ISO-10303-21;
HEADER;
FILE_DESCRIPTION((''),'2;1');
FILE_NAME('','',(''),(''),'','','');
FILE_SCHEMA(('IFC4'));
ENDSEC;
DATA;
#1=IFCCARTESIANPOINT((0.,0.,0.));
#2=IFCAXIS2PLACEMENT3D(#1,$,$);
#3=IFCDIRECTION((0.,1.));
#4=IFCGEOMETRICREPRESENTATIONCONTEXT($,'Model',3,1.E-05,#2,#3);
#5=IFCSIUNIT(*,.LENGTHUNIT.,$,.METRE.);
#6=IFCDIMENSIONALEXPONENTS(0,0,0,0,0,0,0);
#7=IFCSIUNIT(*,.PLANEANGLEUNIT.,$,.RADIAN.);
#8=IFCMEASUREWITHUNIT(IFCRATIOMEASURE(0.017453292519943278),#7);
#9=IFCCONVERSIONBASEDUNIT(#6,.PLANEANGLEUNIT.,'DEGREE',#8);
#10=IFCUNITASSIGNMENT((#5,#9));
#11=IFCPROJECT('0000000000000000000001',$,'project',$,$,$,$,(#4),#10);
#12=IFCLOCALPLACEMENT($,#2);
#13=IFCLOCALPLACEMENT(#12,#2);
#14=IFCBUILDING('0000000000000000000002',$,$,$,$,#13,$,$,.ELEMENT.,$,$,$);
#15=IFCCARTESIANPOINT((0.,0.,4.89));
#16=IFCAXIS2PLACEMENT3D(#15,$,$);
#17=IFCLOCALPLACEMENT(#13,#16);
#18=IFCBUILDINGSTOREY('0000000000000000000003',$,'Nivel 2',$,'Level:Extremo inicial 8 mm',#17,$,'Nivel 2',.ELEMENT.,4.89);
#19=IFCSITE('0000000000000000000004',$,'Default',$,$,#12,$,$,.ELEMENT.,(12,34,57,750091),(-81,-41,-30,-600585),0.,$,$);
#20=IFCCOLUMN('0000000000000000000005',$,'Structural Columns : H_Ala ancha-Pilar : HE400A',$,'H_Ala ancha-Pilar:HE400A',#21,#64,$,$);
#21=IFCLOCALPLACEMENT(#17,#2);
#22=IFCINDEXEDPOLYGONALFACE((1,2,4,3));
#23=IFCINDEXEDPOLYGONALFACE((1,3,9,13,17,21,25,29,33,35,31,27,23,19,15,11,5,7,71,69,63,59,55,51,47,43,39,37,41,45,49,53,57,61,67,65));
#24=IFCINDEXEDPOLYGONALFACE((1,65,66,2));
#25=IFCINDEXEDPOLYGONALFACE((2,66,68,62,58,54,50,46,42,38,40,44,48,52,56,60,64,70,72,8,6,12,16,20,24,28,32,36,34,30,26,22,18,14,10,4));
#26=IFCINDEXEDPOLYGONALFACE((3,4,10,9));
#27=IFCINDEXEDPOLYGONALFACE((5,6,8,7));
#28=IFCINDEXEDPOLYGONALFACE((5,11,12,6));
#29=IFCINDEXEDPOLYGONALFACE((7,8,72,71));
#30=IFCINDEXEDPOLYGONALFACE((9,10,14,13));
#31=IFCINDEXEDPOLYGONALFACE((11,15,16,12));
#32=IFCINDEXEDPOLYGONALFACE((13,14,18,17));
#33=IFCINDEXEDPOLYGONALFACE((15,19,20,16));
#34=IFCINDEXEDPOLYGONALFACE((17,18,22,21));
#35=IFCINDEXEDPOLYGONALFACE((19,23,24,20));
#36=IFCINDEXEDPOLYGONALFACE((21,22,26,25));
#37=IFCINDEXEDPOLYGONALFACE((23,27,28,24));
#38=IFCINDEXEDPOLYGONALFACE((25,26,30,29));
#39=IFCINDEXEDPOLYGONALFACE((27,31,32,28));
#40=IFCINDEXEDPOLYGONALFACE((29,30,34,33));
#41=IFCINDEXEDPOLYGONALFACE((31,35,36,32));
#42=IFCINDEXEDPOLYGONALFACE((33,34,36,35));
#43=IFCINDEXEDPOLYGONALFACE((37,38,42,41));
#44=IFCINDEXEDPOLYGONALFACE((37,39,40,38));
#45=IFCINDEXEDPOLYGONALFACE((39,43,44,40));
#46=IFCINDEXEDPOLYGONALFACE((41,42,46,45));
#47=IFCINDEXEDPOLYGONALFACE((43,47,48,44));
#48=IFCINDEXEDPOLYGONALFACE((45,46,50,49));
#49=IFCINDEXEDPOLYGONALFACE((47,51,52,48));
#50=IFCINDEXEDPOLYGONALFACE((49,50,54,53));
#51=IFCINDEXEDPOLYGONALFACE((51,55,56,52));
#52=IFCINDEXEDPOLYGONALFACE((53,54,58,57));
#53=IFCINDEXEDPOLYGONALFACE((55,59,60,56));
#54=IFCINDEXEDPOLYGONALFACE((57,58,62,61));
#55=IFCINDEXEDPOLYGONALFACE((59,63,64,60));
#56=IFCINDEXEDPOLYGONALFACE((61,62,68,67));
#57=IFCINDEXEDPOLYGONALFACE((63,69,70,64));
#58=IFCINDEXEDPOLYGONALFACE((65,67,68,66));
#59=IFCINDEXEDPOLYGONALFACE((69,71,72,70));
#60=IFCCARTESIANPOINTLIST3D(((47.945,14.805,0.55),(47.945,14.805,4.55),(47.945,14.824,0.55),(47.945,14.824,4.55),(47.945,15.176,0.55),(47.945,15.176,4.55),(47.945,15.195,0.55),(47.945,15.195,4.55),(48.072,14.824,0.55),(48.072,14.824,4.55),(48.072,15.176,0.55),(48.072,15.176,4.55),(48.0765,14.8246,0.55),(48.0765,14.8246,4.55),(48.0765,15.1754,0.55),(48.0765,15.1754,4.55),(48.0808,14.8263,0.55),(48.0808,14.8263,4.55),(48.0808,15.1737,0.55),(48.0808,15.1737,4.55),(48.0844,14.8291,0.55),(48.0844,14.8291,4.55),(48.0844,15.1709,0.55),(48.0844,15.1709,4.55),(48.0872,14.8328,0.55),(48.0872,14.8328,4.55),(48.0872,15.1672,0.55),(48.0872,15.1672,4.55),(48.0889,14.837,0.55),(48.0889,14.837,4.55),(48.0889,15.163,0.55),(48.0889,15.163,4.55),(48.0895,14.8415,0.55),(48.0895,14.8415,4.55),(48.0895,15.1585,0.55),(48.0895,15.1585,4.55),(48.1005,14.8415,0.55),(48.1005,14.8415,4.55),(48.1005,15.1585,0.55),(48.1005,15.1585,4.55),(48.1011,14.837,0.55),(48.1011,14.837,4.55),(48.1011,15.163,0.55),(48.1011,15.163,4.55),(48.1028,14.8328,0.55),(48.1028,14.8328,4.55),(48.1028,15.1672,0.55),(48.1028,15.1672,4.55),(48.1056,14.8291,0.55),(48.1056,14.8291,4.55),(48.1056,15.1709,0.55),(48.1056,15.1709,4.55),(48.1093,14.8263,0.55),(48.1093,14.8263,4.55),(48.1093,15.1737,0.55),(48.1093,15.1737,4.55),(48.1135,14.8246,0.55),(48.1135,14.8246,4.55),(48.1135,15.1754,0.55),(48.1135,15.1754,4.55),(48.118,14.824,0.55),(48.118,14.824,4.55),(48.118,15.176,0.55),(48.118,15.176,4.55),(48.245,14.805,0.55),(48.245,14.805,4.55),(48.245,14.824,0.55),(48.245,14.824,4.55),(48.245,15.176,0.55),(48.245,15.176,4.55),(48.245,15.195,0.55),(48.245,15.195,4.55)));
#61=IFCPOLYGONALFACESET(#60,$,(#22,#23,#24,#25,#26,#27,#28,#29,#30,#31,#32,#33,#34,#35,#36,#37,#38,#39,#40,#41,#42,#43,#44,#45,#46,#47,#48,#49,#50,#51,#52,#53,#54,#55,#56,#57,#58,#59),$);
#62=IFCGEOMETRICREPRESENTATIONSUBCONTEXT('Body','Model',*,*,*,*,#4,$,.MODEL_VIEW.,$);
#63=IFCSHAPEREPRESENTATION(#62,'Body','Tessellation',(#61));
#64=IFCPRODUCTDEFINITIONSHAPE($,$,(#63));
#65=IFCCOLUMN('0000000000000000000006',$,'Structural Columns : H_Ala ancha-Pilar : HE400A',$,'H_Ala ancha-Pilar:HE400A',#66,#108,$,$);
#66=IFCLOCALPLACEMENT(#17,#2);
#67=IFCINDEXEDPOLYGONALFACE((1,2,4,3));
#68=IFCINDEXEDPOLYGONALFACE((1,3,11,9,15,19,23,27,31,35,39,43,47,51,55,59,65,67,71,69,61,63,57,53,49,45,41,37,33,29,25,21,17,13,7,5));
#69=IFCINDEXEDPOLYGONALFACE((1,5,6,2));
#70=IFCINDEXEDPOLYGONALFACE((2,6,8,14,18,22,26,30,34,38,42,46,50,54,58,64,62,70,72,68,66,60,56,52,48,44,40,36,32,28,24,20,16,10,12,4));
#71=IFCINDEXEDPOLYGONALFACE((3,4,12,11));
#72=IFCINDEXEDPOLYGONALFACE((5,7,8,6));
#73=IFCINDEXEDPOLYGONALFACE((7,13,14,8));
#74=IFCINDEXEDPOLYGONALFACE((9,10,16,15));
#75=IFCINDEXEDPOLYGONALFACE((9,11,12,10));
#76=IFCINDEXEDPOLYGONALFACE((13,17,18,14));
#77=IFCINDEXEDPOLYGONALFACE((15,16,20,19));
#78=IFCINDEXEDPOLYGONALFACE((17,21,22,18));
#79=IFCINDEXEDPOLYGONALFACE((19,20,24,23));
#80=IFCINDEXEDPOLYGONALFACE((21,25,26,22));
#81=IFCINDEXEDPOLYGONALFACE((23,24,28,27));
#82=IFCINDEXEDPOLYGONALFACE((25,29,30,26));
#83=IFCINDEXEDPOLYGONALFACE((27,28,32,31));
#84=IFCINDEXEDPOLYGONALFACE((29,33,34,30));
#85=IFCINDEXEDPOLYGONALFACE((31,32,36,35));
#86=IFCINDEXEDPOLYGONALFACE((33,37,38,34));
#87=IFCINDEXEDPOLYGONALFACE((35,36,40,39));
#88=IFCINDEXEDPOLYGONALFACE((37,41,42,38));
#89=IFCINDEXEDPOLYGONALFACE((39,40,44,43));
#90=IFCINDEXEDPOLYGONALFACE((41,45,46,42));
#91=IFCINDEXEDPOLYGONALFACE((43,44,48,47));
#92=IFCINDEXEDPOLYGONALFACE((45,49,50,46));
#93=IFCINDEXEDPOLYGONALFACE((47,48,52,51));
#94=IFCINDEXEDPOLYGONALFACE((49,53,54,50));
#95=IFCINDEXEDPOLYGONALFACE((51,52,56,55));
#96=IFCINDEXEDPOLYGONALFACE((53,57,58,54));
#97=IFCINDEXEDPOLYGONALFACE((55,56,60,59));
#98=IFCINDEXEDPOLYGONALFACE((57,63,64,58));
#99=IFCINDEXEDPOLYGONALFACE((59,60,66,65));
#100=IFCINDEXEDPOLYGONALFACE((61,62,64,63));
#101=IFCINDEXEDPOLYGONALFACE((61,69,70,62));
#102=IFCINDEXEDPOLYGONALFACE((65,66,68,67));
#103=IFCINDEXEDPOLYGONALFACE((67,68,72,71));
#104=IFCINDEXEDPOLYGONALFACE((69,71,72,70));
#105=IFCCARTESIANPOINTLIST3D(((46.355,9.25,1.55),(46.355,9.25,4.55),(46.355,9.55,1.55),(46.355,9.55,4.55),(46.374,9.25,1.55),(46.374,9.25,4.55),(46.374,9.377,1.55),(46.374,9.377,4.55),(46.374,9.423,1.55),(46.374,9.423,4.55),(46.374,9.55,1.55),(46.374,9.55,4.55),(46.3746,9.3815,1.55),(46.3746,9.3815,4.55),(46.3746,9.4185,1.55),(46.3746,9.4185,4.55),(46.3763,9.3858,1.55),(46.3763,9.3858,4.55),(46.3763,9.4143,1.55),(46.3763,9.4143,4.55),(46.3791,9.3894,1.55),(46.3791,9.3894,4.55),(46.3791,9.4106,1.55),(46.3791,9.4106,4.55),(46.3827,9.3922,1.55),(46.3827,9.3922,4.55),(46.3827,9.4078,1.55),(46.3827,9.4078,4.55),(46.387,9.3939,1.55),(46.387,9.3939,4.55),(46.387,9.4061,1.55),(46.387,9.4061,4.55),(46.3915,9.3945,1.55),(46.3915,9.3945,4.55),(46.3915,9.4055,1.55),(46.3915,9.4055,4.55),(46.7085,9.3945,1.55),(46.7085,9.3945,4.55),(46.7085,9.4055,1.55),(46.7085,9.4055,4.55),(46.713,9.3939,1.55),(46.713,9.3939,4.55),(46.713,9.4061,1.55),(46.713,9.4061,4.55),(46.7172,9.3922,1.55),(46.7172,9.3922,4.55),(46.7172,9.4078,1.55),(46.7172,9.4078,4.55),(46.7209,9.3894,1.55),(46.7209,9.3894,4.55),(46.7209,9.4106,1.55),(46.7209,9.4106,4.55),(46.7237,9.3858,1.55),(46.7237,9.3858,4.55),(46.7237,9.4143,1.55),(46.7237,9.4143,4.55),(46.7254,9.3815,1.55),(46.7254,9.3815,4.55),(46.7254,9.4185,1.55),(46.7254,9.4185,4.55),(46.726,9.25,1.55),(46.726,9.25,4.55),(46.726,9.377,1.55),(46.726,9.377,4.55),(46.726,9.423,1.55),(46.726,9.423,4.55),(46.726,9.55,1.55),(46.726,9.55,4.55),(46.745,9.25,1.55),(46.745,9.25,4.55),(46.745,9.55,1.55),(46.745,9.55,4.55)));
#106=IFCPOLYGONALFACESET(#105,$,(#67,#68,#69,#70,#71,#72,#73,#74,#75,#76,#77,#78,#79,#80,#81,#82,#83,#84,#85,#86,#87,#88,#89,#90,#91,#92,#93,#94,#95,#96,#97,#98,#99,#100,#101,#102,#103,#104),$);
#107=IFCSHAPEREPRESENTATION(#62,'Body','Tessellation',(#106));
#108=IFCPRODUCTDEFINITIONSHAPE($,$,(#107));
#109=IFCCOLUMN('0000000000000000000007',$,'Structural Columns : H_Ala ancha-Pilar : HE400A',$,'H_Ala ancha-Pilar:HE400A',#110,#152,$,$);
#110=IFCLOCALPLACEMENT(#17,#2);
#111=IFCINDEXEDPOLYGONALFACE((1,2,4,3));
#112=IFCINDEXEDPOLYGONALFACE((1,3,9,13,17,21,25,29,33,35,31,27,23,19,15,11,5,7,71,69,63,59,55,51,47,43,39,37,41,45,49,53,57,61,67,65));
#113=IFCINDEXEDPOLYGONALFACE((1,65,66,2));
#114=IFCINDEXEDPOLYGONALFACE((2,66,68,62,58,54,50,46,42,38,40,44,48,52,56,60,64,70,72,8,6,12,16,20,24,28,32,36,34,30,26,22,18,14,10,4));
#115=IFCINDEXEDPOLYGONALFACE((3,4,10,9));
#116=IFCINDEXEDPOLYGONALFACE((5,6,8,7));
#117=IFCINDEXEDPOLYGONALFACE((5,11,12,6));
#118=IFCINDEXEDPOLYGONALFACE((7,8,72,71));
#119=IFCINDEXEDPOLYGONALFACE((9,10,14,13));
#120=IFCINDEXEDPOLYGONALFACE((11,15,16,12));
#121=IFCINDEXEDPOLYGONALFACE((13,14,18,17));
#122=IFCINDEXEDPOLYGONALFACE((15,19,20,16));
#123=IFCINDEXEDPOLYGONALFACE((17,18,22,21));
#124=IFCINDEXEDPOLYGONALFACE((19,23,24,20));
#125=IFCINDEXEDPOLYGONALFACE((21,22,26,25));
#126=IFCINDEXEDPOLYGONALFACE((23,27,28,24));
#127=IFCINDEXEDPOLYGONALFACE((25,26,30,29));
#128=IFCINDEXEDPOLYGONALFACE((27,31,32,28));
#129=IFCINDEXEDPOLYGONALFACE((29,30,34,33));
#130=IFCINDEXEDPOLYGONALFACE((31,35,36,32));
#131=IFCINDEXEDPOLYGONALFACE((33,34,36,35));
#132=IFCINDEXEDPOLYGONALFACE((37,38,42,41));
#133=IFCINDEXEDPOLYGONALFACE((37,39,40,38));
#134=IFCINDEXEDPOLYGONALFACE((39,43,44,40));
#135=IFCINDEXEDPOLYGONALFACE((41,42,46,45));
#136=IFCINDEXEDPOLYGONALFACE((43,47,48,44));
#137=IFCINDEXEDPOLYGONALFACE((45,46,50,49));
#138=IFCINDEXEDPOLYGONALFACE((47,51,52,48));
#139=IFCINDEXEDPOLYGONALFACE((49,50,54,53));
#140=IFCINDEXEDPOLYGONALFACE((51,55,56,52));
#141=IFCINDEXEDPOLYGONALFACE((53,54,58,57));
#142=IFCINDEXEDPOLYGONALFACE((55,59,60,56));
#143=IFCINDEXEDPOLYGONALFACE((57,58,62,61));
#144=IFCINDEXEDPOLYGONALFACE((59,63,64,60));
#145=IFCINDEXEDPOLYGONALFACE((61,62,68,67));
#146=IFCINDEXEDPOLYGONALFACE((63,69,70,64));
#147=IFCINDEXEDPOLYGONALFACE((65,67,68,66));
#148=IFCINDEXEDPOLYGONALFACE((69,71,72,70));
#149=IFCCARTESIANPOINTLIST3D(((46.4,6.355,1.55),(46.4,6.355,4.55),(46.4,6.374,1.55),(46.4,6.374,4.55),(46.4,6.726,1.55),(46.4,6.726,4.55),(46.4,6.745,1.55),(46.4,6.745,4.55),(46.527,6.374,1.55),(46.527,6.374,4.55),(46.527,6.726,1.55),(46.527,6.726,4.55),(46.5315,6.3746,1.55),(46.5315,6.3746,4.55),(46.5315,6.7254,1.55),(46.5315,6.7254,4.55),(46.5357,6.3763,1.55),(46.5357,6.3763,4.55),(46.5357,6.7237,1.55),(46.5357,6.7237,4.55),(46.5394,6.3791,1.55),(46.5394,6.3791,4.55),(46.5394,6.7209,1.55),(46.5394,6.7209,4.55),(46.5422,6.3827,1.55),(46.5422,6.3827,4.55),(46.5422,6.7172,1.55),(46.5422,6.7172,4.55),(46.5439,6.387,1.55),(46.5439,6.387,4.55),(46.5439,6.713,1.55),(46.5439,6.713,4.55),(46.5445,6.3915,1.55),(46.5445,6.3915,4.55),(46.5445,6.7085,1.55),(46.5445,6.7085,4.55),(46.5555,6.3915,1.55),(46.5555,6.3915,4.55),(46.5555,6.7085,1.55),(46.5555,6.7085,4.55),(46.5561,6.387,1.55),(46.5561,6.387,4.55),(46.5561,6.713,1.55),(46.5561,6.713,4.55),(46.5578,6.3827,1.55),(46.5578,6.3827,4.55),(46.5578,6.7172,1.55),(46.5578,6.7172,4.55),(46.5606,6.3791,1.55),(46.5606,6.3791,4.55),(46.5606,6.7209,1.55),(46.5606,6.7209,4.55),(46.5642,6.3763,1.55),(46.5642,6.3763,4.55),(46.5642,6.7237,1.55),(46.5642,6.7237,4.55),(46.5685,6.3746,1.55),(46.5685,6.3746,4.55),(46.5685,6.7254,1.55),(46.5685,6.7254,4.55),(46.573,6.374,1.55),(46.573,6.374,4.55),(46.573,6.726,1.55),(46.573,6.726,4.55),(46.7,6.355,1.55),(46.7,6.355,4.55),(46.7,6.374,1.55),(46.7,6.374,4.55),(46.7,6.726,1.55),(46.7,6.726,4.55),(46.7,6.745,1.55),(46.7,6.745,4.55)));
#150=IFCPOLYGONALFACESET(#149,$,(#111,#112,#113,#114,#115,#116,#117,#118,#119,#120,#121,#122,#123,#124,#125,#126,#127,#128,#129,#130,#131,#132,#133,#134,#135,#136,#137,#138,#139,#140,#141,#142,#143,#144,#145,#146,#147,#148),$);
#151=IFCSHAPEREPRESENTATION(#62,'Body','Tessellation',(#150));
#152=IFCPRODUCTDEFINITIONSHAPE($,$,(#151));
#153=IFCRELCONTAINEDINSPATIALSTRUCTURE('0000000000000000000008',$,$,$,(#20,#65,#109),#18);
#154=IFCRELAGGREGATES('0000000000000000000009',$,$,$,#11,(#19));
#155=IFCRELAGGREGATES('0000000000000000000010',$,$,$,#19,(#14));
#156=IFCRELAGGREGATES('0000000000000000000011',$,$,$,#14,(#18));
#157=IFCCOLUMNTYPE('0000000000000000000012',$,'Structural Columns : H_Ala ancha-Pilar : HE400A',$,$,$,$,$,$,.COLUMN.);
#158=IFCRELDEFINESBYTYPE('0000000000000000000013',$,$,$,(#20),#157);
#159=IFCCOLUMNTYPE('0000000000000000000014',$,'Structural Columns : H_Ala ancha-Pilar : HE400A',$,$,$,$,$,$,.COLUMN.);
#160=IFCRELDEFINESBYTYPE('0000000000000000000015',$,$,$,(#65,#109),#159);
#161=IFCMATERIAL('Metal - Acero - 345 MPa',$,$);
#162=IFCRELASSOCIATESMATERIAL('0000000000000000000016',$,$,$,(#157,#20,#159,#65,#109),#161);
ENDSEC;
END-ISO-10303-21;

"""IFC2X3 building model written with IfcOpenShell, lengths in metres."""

from ifc_helpers import new_model, entity, si_unit, converted_unit, direction, frame, frame_2d, origin, place, context, subcontext, project, spatial, polyline, circle_curve, parameter, trimmed, segment, composite_curve, outline, extrude, source, transform, mapped, material, type_object, type_shapes, element, save


model = new_model("IFC2X3")

# Units and contexts
model_context = context("Model", 3, precision=1e-05, world=origin(), true_north=direction((0.0, 1.0)))
body_context = subcontext(model_context, "Body", "Model", "MODEL_VIEW")
ifc_project = project(units=[si_unit("LENGTHUNIT", "METRE"), converted_unit("PLANEANGLEUNIT", "DEGREE", entity("IfcRatioMeasure", 0.017453292519943278), si_unit("PLANEANGLEUNIT", "RADIAN"), dimensions=[0, 0, 0, 0, 0, 0, 0])], contexts=[model_context])

# Site, building, storey
site_placement = place(None, origin())
site = spatial("IfcSite", under=ifc_project, at=site_placement, Name="Default", CompositionType="ELEMENT", RefLatitude=(12, 34, 57, 750091), RefLongitude=(-81, -41, -30, -600585), RefElevation=0.0)
building_placement = place(site_placement, origin())
building = spatial("IfcBuilding", under=site, at=building_placement, CompositionType="ELEMENT")
storey_placement = place(building_placement, frame((0.0, 0.0, 4.89)))
storey = spatial("IfcBuildingStorey", under=building, at=storey_placement, Name="Nivel 2", ObjectType="Level:Extremo inicial 8 mm", LongName="Nivel 2", CompositionType="ELEMENT", Elevation=4.89)

# Columns
ifc_material_1 = material(Name="Metal - Acero - 345 MPa")
column_type_1 = type_object("IfcColumnType", Name="Structural Columns : H_Ala ancha-Pilar : HE400A", PredefinedType="COLUMN", material=ifc_material_1)
shared_shape_1 = source(origin(), body_context, "Body", "SweptSolid", [
    extrude(outline(composite_curve([segment(polyline([(0.176, -0.15), (0.195, -0.15)]), True, "CONTINUOUS"), segment(polyline([(0.195, -0.15), (0.195, 0.15)]), True, "CONTINUOUS"), segment(polyline([(0.195, 0.15), (0.176, 0.15)]), True, "CONTINUOUS"), segment(polyline([(0.176, 0.15), (0.176, 0.023)]), True, "CONTINUOUS"), segment(trimmed(circle_curve(frame_2d((0.1585, 0.023), x_axis=(1.0, 0.0)), 0.0175), [parameter(270.0)], [parameter(0.0)], True, "PARAMETER"), False, "CONTINUOUS"), segment(polyline([(0.1585, 0.0055), (-0.1585, 0.0055)]), True, "CONTINUOUS"), segment(trimmed(circle_curve(frame_2d((-0.1585, 0.023), x_axis=(0.0, -1.0)), 0.0175), [parameter(270.0)], [parameter(0.0)], True, "PARAMETER"), False, "CONTINUOUS"), segment(polyline([(-0.176, 0.023), (-0.176, 0.15)]), True, "CONTINUOUS"), segment(polyline([(-0.176, 0.15), (-0.195, 0.15)]), True, "CONTINUOUS"), segment(polyline([(-0.195, 0.15), (-0.195, -0.15)]), True, "CONTINUOUS"), segment(polyline([(-0.195, -0.15), (-0.176, -0.15)]), True, "CONTINUOUS"), segment(polyline([(-0.176, -0.15), (-0.176, -0.023)]), True, "CONTINUOUS"), segment(trimmed(circle_curve(frame_2d((-0.1585, -0.023), x_axis=(-1.0, 0.0)), 0.0175), [parameter(270.0)], [parameter(0.0)], True, "PARAMETER"), False, "CONTINUOUS"), segment(polyline([(-0.1585, -0.0055), (0.1585, -0.0055)]), True, "CONTINUOUS"), segment(trimmed(circle_curve(frame_2d((0.1585, -0.023), x_axis=(0.0, 1.0)), 0.0175), [parameter(270.0)], [parameter(0.0)], True, "PARAMETER"), False, "CONTINUOUS"), segment(polyline([(0.176, -0.023), (0.176, -0.15)]), True, "CONTINUOUS")], self_intersect=False)), frame((0.0, 0.0, 5.44), z_axis=(0.0, 0.0, 1.0), x_axis=(0.0, -1.0, 0.0)), (0.0, 0.0, 1.0), 4.0),
])
type_shapes(column_type_1, [shared_shape_1])
column_1_placement = place(storey_placement, frame((48.095, 15.0, -4.89), z_axis=(0.0, 0.0, 1.0), x_axis=(-1.0, 0.0, 0.0)))
element("IfcColumn", 1, at=column_1_placement, inside=storey, type_object=column_type_1, material=ifc_material_1, Name="Structural Columns : H_Ala ancha-Pilar : HE400A", ObjectType="H_Ala ancha-Pilar:HE400A", context=body_context, shape_type="MappedRepresentation", body=[
    mapped(shared_shape_1, transform((0.0, 0.0, 0.0), scale=1.0)),
])
column_type_2 = type_object("IfcColumnType", Name="Structural Columns : H_Ala ancha-Pilar : HE400A", PredefinedType="COLUMN", material=ifc_material_1)
shared_shape_2 = source(origin(), body_context, "Body", "SweptSolid", [
    extrude(outline(composite_curve([segment(polyline([(0.176, -0.15), (0.195, -0.15)]), True, "CONTINUOUS"), segment(polyline([(0.195, -0.15), (0.195, 0.15)]), True, "CONTINUOUS"), segment(polyline([(0.195, 0.15), (0.176, 0.15)]), True, "CONTINUOUS"), segment(polyline([(0.176, 0.15), (0.176, 0.023)]), True, "CONTINUOUS"), segment(trimmed(circle_curve(frame_2d((0.1585, 0.023), x_axis=(1.0, 0.0)), 0.0175), [parameter(270.0)], [parameter(0.0)], True, "PARAMETER"), False, "CONTINUOUS"), segment(polyline([(0.1585, 0.0055), (-0.1585, 0.0055)]), True, "CONTINUOUS"), segment(trimmed(circle_curve(frame_2d((-0.1585, 0.023), x_axis=(0.0, -1.0)), 0.0175), [parameter(270.0)], [parameter(0.0)], True, "PARAMETER"), False, "CONTINUOUS"), segment(polyline([(-0.176, 0.023), (-0.176, 0.15)]), True, "CONTINUOUS"), segment(polyline([(-0.176, 0.15), (-0.195, 0.15)]), True, "CONTINUOUS"), segment(polyline([(-0.195, 0.15), (-0.195, -0.15)]), True, "CONTINUOUS"), segment(polyline([(-0.195, -0.15), (-0.176, -0.15)]), True, "CONTINUOUS"), segment(polyline([(-0.176, -0.15), (-0.176, -0.023)]), True, "CONTINUOUS"), segment(trimmed(circle_curve(frame_2d((-0.1585, -0.023), x_axis=(-1.0, 0.0)), 0.0175), [parameter(270.0)], [parameter(0.0)], True, "PARAMETER"), False, "CONTINUOUS"), segment(polyline([(-0.1585, -0.0055), (0.1585, -0.0055)]), True, "CONTINUOUS"), segment(trimmed(circle_curve(frame_2d((0.1585, -0.023), x_axis=(0.0, 1.0)), 0.0175), [parameter(270.0)], [parameter(0.0)], True, "PARAMETER"), False, "CONTINUOUS"), segment(polyline([(0.176, -0.023), (0.176, -0.15)]), True, "CONTINUOUS")], self_intersect=False)), frame((0.0, 0.0, 6.44), z_axis=(0.0, 0.0, 1.0), x_axis=(0.0, -1.0, 0.0)), (0.0, 0.0, 1.0), 3.0),
])
type_shapes(column_type_2, [shared_shape_2])
column_2_placement = place(storey_placement, frame((46.55, 9.4, -4.89), z_axis=(0.0, 0.0, 1.0), x_axis=(0.0, 1.0, 0.0)))
element("IfcColumn", 2, at=column_2_placement, inside=storey, type_object=column_type_2, material=ifc_material_1, Name="Structural Columns : H_Ala ancha-Pilar : HE400A", ObjectType="H_Ala ancha-Pilar:HE400A", context=body_context, shape_type="MappedRepresentation", body=[
    mapped(shared_shape_2, transform((0.0, 0.0, 0.0), scale=1.0)),
])
column_3_placement = place(storey_placement, frame((46.55, 6.55, -4.89)))
element("IfcColumn", 3, at=column_3_placement, inside=storey, type_object=column_type_2, material=ifc_material_1, Name="Structural Columns : H_Ala ancha-Pilar : HE400A", ObjectType="H_Ala ancha-Pilar:HE400A", context=body_context, shape_type="MappedRepresentation", body=[
    mapped(shared_shape_2, transform((0.0, 0.0, 0.0), scale=1.0)),
])

save(model, "model.ifc")
